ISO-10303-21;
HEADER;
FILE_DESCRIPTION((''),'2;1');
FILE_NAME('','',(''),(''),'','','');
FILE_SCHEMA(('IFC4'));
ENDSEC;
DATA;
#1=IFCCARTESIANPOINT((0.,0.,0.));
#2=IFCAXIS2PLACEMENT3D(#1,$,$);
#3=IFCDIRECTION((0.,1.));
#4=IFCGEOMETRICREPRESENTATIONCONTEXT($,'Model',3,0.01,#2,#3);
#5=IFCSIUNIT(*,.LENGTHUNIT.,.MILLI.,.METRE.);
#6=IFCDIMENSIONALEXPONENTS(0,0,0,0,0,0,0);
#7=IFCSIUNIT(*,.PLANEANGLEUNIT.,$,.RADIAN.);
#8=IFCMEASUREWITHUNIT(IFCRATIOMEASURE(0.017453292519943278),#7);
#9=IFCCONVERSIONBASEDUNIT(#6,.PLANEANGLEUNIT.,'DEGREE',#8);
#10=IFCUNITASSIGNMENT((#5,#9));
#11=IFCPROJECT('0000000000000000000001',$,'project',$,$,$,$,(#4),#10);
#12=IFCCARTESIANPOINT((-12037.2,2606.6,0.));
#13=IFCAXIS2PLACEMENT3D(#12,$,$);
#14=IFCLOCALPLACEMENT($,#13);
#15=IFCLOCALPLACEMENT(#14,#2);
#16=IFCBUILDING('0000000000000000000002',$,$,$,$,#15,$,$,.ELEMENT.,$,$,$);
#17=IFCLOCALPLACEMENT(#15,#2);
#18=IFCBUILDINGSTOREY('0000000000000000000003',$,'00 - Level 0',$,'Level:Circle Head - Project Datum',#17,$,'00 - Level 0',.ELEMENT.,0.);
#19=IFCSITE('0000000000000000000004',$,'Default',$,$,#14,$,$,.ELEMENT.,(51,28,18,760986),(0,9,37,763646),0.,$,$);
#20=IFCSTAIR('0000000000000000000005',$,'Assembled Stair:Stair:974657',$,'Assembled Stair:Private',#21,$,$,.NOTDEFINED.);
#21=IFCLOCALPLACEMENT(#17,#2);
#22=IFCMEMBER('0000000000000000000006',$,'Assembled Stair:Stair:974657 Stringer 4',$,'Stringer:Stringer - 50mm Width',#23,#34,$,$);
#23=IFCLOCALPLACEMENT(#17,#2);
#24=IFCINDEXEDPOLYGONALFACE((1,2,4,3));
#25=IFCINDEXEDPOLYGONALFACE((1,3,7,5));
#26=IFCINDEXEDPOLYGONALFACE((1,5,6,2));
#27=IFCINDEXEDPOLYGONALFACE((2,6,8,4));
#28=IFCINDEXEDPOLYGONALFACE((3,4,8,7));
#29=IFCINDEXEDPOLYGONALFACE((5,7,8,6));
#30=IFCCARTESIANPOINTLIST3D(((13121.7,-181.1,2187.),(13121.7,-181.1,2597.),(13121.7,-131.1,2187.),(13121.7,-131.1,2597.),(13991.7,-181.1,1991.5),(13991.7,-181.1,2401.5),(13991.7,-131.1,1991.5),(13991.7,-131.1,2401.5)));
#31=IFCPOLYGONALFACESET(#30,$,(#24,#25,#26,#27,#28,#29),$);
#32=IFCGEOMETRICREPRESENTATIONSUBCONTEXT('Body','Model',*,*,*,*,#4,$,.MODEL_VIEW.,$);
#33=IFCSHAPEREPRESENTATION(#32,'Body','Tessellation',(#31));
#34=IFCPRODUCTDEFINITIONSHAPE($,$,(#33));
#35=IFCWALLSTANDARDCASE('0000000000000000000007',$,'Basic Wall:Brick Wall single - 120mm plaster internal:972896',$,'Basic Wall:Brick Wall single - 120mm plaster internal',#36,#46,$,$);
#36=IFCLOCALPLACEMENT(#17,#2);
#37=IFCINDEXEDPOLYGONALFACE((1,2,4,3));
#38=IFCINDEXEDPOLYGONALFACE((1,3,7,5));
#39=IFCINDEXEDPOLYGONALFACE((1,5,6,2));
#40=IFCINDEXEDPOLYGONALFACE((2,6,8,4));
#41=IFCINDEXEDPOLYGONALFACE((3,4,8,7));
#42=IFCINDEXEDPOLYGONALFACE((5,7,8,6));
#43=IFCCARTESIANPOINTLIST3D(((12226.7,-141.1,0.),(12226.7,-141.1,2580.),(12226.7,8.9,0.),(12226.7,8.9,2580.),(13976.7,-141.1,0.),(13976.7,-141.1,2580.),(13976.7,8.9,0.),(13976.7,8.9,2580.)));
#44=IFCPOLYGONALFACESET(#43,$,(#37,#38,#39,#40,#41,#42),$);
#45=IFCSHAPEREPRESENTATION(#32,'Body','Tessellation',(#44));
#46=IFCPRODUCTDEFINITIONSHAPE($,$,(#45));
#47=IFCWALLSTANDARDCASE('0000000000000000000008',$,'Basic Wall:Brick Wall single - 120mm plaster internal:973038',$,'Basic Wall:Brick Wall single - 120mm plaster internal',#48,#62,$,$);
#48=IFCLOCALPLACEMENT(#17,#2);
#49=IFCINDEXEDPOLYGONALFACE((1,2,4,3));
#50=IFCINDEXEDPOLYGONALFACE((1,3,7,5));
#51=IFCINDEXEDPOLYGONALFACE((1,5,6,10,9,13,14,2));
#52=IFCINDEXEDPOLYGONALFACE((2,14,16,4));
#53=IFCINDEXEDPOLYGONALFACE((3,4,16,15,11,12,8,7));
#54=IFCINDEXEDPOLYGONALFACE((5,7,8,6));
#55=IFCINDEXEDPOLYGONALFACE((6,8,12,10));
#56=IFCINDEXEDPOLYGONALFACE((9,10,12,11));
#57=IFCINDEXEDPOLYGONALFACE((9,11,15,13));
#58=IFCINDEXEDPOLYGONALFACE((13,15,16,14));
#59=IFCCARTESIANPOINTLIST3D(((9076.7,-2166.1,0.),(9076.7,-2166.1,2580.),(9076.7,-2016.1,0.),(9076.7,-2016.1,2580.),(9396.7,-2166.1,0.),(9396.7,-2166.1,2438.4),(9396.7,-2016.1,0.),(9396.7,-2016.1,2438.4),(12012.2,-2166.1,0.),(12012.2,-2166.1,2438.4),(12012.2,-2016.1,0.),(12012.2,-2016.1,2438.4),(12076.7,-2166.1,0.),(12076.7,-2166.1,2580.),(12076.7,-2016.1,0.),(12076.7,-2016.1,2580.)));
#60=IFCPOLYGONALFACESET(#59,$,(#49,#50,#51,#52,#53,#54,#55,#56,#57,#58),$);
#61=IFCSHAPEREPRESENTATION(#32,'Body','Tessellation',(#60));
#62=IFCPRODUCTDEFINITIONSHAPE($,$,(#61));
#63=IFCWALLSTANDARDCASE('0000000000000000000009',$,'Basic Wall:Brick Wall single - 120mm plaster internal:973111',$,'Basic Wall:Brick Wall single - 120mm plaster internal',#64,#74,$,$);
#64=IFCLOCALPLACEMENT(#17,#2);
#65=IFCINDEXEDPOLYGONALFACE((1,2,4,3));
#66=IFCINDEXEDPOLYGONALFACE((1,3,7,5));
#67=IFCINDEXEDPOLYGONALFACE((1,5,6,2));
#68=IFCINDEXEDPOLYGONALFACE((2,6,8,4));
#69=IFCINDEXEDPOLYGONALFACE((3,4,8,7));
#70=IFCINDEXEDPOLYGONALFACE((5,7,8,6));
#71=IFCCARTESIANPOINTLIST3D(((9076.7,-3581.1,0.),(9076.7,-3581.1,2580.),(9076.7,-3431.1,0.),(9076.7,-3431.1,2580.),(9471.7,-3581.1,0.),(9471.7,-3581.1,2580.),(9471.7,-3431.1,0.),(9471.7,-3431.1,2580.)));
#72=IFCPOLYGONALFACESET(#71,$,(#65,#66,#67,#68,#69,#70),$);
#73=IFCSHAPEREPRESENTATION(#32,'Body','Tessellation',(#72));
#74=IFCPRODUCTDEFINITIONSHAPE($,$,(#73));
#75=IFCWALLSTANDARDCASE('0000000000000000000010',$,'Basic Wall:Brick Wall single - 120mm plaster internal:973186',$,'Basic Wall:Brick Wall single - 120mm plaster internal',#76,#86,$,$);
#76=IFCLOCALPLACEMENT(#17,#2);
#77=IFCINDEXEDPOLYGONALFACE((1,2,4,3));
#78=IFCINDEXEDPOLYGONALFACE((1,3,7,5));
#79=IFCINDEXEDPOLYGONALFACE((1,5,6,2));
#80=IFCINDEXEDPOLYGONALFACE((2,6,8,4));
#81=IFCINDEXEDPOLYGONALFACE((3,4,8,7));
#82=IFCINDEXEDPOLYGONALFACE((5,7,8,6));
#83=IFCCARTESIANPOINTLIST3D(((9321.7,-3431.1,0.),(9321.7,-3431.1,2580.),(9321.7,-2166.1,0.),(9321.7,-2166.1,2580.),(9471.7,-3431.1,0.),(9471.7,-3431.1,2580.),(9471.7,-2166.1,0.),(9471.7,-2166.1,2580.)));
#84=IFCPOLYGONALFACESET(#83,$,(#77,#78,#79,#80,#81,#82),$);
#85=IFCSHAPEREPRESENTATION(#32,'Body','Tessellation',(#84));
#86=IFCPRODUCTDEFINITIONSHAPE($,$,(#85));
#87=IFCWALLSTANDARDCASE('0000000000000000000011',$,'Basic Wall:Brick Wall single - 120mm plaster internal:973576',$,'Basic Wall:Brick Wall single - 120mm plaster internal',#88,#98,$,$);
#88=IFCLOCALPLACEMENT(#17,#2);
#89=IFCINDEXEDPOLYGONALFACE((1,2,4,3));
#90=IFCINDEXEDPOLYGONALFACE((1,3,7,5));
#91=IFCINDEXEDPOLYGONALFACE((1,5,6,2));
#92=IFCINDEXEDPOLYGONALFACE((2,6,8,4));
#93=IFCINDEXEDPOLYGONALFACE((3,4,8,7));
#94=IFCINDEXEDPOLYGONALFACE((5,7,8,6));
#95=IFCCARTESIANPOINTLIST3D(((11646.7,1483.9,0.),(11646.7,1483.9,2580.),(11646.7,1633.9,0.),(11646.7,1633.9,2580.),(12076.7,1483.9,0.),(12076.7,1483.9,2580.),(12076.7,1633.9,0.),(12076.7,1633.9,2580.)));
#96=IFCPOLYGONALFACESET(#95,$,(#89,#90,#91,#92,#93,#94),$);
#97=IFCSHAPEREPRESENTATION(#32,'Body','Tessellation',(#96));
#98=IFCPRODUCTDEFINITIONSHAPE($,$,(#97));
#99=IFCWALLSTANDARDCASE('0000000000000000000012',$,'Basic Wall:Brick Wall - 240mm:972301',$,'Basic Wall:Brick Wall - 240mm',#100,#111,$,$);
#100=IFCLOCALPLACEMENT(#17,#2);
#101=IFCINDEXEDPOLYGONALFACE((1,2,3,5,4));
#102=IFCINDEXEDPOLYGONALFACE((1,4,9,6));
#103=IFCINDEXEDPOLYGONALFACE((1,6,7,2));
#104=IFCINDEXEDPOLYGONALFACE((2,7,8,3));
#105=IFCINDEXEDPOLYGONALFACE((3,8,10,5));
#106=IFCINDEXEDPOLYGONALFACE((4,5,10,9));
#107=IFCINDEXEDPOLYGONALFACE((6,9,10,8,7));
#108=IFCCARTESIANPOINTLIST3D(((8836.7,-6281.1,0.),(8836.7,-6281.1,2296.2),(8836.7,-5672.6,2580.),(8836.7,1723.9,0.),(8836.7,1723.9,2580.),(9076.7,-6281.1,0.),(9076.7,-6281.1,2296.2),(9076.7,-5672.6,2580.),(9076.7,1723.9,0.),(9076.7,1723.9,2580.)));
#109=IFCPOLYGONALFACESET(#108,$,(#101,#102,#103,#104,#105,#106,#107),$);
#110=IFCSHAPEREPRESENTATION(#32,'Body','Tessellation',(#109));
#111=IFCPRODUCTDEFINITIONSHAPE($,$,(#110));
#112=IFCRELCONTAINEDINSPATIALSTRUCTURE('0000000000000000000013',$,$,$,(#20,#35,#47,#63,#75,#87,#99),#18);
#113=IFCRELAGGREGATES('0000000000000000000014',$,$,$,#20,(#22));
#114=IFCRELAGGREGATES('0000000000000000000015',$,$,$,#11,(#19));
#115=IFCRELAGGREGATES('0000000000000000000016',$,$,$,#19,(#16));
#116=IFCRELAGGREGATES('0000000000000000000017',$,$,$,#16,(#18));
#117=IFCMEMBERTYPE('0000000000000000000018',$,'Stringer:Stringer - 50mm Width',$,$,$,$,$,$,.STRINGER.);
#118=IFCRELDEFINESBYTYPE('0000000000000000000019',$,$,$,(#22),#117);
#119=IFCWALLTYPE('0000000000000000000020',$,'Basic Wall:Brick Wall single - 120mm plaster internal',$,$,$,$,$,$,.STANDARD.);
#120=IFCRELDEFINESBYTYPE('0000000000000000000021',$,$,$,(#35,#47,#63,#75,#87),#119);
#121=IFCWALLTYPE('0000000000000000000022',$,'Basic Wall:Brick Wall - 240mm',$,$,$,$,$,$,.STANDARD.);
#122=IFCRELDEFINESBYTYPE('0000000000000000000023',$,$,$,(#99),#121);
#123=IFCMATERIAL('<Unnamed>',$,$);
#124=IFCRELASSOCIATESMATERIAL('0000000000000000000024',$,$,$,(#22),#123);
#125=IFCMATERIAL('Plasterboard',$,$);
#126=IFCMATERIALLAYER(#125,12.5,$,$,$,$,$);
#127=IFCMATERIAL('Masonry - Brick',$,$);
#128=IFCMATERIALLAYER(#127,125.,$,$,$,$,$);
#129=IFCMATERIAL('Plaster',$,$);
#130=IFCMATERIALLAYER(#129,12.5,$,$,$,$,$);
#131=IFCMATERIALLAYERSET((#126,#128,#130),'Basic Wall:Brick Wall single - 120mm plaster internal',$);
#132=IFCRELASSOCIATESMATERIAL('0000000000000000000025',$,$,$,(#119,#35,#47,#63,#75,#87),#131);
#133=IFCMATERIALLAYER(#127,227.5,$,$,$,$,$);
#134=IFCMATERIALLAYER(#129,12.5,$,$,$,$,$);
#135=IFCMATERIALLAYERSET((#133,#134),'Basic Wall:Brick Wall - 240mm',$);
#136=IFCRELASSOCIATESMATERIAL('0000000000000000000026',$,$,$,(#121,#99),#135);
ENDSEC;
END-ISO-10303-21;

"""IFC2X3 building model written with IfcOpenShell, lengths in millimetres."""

from ifc_helpers import new_model, entity, si_unit, converted_unit, direction, frame, frame_2d, origin, place, context, subcontext, project, spatial, polyline, rectangle, outline, extrude, clip, bounded_halfspace, material, layer, layer_set, layer_usage, type_object, element, aggregate, save


model = new_model("IFC2X3")

# Units and contexts
model_context = context("Model", 3, precision=0.01, world=origin(), true_north=direction((0.0, 1.0)))
body_context = subcontext(model_context, "Body", "Model", "MODEL_VIEW")
ifc_project = project(units=[si_unit("LENGTHUNIT", "METRE", prefix="MILLI"), converted_unit("PLANEANGLEUNIT", "DEGREE", entity("IfcRatioMeasure", 0.017453292519943278), si_unit("PLANEANGLEUNIT", "RADIAN"), dimensions=[0, 0, 0, 0, 0, 0, 0])], contexts=[model_context])

# Site, building, storey
site_placement = place(None, frame((-12037.2, 2606.6, 0.0)))
site = spatial("IfcSite", under=ifc_project, at=site_placement, Name="Default", CompositionType="ELEMENT", RefLatitude=(51, 28, 18, 760986), RefLongitude=(0, 9, 37, 763646), RefElevation=0.0)
building_placement = place(site_placement, origin())
building = spatial("IfcBuilding", under=site, at=building_placement, CompositionType="ELEMENT")
storey_placement = place(building_placement, origin())
storey = spatial("IfcBuildingStorey", under=building, at=storey_placement, Name="00 - Level 0", ObjectType="Level:Circle Head - Project Datum", LongName="00 - Level 0", CompositionType="ELEMENT", Elevation=0.0)

# Stair, member
stair_placement = place(storey_placement, origin())
stair = element("IfcStair", 1, at=stair_placement, inside=storey, Name="Assembled Stair:Stair:974657", ObjectType="Assembled Stair:Private", ShapeType="NOTDEFINED")
ifc_material_1 = material(Name="<Unnamed>")
member_type = type_object("IfcMemberType", Name="Stringer:Stringer - 50mm Width", PredefinedType="STRINGER")
member_1_placement = place(stair_placement, origin())
member_1 = element("IfcMember", 2, at=member_1_placement, type_object=member_type, material=ifc_material_1, Name="Assembled Stair:Stair:974657 Stringer 4", ObjectType="Stringer:Stringer - 50mm Width", context=body_context, shape_type="SweptSolid", body=[
    extrude(outline(polyline([(-490.8, -200.0), (400.9, -200.0), (490.8, 200.0), (-400.9, 200.0), (-490.8, -200.0)])), frame((13556.7, -181.1, 2294.3), z_axis=(0.0, 1.0, 0.0), x_axis=(-0.975664, 0.0, 0.21927)), (0.0, 0.0, 1.0), 50.0),
])
aggregate(stair, [member_1])

# Shared definitions
ifc_material_2 = material(Name="Plasterboard")
ifc_layer_1 = layer(ifc_material_2, 12.5)
ifc_material_3 = material(Name="Masonry - Brick")
ifc_layer_2 = layer(ifc_material_3, 125.0)
ifc_material_4 = material(Name="Plaster")
ifc_layer_3 = layer(ifc_material_4, 12.5)
ifc_layer_set_1 = layer_set([ifc_layer_1, ifc_layer_2, ifc_layer_3], Name="Basic Wall:Brick Wall single - 120mm plaster internal")
wall_type_1 = type_object("IfcWallType", Name="Basic Wall:Brick Wall single - 120mm plaster internal", PredefinedType="STANDARD", material=ifc_layer_set_1)

# Wall
ifc_layer_usage_1 = layer_usage(ifc_layer_set_1, "AXIS2", "NEGATIVE", 75.0)
wall_1_placement = place(storey_placement, frame((12226.7, -66.1, 0.0)))
element("IfcWallStandardCase", 3, at=wall_1_placement, inside=storey, type_object=wall_type_1, material=ifc_layer_usage_1, Name="Basic Wall:Brick Wall single - 120mm plaster internal:972896", ObjectType="Basic Wall:Brick Wall single - 120mm plaster internal", context=body_context, shape_type="SweptSolid", body=[
    extrude(rectangle(XDim=1750.0, YDim=150.0, at=frame_2d((875.0, 0.0), x_axis=(-1.0, 0.0))), origin(), (0.0, 0.0, 1.0), 2580.0),
])

# Wall, opening
ifc_layer_usage_2 = layer_usage(ifc_layer_set_1, "AXIS2", "NEGATIVE", 75.0)
wall_2_placement = place(storey_placement, frame((12076.7, -2091.1, 0.0), z_axis=(0.0, 0.0, 1.0), x_axis=(-1.0, 0.0, 0.0)))
wall_2 = element("IfcWallStandardCase", 4, at=wall_2_placement, inside=storey, type_object=wall_type_1, material=ifc_layer_usage_2, Name="Basic Wall:Brick Wall single - 120mm plaster internal:973038", ObjectType="Basic Wall:Brick Wall single - 120mm plaster internal", context=body_context, shape_type="SweptSolid", body=[
    extrude(rectangle(XDim=3000.0, YDim=150.0, at=frame_2d((1500.0, 0.0), x_axis=(1.0, 0.0))), origin(), (0.0, 0.0, 1.0), 2580.0),
])
opening_1_placement = place(wall_2_placement, origin())
element("IfcOpeningElement", 5, at=opening_1_placement, cuts=wall_2, ObjectType="Opening", context=body_context, shape_type="SweptSolid", body=[
    extrude(rectangle(XDim=2438.4, YDim=2615.5, at=frame_2d((0.0, 0.0), x_axis=(1.0, 0.0))), frame((1372.2, -75.0, 1219.2), z_axis=(0.0, 1.0, 0.0), x_axis=(0.0, 0.0, -1.0)), (0.0, 0.0, 1.0), 150.0),
])

# Walls
ifc_layer_usage_3 = layer_usage(ifc_layer_set_1, "AXIS2", "NEGATIVE", 75.0)
wall_3_placement = place(storey_placement, frame((9076.7, -3506.1, 0.0)))
element("IfcWallStandardCase", 6, at=wall_3_placement, inside=storey, type_object=wall_type_1, material=ifc_layer_usage_3, Name="Basic Wall:Brick Wall single - 120mm plaster internal:973111", ObjectType="Basic Wall:Brick Wall single - 120mm plaster internal", context=body_context, shape_type="SweptSolid", body=[
    extrude(rectangle(XDim=395.0, YDim=150.0, at=frame_2d((197.5, 0.0), x_axis=(-1.0, 0.0))), origin(), (0.0, 0.0, 1.0), 2580.0),
])
ifc_layer_usage_4 = layer_usage(ifc_layer_set_1, "AXIS2", "NEGATIVE", 75.0)
wall_4_placement = place(storey_placement, frame((9396.7, -3431.1, 0.0), z_axis=(0.0, 0.0, 1.0), x_axis=(0.0, 1.0, 0.0)))
element("IfcWallStandardCase", 7, at=wall_4_placement, inside=storey, type_object=wall_type_1, material=ifc_layer_usage_4, Name="Basic Wall:Brick Wall single - 120mm plaster internal:973186", ObjectType="Basic Wall:Brick Wall single - 120mm plaster internal", context=body_context, shape_type="SweptSolid", body=[
    extrude(rectangle(XDim=1265.0, YDim=150.0, at=frame_2d((632.5, 0.0), x_axis=(-1.0, 0.0))), origin(), (0.0, 0.0, 1.0), 2580.0),
])
ifc_layer_usage_5 = layer_usage(ifc_layer_set_1, "AXIS2", "NEGATIVE", 75.0)
wall_5_placement = place(storey_placement, frame((11646.7, 1558.9, 0.0)))
element("IfcWallStandardCase", 8, at=wall_5_placement, inside=storey, type_object=wall_type_1, material=ifc_layer_usage_5, Name="Basic Wall:Brick Wall single - 120mm plaster internal:973576", ObjectType="Basic Wall:Brick Wall single - 120mm plaster internal", context=body_context, shape_type="SweptSolid", body=[
    extrude(rectangle(XDim=430.0, YDim=150.0, at=frame_2d((215.0, 0.0), x_axis=(-1.0, 0.0))), origin(), (0.0, 0.0, 1.0), 2580.0),
])
ifc_layer_4 = layer(ifc_material_3, 227.5)
ifc_layer_5 = layer(ifc_material_4, 12.5)
ifc_layer_set_2 = layer_set([ifc_layer_4, ifc_layer_5], Name="Basic Wall:Brick Wall - 240mm")
ifc_layer_usage_6 = layer_usage(ifc_layer_set_2, "AXIS2", "NEGATIVE", 120.0)
wall_type_2 = type_object("IfcWallType", Name="Basic Wall:Brick Wall - 240mm", PredefinedType="STANDARD", material=ifc_layer_set_2)
wall_6_placement = place(storey_placement, frame((8956.7, -6281.1, 0.0), z_axis=(0.0, 0.0, 1.0), x_axis=(0.0, 1.0, 0.0)))
element("IfcWallStandardCase", 9, at=wall_6_placement, inside=storey, type_object=wall_type_2, material=ifc_layer_usage_6, Name="Basic Wall:Brick Wall - 240mm:972301", ObjectType="Basic Wall:Brick Wall - 240mm", context=body_context, shape_type="Clipping", body=[
    clip(extrude(rectangle(XDim=8005.0, YDim=240.0, at=frame_2d((4002.5, 0.0), x_axis=(-1.0, 0.0))), origin(), (0.0, 0.0, 1.0), 2580.0), bounded_halfspace(frame((0.0, -120.0, 2296.2), z_axis=(-0.422618, 0.0, 0.906308), x_axis=(0.0, -1.0, 0.0)), False, frame((0.0, -120.0, 2296.2)), polyline([(0.0, 0.0), (182880.0, 0.0), (182880.0, 73152.0), (0.0, 73152.0), (0.0, 0.0)]))),
])

save(model, "model.ifc")
